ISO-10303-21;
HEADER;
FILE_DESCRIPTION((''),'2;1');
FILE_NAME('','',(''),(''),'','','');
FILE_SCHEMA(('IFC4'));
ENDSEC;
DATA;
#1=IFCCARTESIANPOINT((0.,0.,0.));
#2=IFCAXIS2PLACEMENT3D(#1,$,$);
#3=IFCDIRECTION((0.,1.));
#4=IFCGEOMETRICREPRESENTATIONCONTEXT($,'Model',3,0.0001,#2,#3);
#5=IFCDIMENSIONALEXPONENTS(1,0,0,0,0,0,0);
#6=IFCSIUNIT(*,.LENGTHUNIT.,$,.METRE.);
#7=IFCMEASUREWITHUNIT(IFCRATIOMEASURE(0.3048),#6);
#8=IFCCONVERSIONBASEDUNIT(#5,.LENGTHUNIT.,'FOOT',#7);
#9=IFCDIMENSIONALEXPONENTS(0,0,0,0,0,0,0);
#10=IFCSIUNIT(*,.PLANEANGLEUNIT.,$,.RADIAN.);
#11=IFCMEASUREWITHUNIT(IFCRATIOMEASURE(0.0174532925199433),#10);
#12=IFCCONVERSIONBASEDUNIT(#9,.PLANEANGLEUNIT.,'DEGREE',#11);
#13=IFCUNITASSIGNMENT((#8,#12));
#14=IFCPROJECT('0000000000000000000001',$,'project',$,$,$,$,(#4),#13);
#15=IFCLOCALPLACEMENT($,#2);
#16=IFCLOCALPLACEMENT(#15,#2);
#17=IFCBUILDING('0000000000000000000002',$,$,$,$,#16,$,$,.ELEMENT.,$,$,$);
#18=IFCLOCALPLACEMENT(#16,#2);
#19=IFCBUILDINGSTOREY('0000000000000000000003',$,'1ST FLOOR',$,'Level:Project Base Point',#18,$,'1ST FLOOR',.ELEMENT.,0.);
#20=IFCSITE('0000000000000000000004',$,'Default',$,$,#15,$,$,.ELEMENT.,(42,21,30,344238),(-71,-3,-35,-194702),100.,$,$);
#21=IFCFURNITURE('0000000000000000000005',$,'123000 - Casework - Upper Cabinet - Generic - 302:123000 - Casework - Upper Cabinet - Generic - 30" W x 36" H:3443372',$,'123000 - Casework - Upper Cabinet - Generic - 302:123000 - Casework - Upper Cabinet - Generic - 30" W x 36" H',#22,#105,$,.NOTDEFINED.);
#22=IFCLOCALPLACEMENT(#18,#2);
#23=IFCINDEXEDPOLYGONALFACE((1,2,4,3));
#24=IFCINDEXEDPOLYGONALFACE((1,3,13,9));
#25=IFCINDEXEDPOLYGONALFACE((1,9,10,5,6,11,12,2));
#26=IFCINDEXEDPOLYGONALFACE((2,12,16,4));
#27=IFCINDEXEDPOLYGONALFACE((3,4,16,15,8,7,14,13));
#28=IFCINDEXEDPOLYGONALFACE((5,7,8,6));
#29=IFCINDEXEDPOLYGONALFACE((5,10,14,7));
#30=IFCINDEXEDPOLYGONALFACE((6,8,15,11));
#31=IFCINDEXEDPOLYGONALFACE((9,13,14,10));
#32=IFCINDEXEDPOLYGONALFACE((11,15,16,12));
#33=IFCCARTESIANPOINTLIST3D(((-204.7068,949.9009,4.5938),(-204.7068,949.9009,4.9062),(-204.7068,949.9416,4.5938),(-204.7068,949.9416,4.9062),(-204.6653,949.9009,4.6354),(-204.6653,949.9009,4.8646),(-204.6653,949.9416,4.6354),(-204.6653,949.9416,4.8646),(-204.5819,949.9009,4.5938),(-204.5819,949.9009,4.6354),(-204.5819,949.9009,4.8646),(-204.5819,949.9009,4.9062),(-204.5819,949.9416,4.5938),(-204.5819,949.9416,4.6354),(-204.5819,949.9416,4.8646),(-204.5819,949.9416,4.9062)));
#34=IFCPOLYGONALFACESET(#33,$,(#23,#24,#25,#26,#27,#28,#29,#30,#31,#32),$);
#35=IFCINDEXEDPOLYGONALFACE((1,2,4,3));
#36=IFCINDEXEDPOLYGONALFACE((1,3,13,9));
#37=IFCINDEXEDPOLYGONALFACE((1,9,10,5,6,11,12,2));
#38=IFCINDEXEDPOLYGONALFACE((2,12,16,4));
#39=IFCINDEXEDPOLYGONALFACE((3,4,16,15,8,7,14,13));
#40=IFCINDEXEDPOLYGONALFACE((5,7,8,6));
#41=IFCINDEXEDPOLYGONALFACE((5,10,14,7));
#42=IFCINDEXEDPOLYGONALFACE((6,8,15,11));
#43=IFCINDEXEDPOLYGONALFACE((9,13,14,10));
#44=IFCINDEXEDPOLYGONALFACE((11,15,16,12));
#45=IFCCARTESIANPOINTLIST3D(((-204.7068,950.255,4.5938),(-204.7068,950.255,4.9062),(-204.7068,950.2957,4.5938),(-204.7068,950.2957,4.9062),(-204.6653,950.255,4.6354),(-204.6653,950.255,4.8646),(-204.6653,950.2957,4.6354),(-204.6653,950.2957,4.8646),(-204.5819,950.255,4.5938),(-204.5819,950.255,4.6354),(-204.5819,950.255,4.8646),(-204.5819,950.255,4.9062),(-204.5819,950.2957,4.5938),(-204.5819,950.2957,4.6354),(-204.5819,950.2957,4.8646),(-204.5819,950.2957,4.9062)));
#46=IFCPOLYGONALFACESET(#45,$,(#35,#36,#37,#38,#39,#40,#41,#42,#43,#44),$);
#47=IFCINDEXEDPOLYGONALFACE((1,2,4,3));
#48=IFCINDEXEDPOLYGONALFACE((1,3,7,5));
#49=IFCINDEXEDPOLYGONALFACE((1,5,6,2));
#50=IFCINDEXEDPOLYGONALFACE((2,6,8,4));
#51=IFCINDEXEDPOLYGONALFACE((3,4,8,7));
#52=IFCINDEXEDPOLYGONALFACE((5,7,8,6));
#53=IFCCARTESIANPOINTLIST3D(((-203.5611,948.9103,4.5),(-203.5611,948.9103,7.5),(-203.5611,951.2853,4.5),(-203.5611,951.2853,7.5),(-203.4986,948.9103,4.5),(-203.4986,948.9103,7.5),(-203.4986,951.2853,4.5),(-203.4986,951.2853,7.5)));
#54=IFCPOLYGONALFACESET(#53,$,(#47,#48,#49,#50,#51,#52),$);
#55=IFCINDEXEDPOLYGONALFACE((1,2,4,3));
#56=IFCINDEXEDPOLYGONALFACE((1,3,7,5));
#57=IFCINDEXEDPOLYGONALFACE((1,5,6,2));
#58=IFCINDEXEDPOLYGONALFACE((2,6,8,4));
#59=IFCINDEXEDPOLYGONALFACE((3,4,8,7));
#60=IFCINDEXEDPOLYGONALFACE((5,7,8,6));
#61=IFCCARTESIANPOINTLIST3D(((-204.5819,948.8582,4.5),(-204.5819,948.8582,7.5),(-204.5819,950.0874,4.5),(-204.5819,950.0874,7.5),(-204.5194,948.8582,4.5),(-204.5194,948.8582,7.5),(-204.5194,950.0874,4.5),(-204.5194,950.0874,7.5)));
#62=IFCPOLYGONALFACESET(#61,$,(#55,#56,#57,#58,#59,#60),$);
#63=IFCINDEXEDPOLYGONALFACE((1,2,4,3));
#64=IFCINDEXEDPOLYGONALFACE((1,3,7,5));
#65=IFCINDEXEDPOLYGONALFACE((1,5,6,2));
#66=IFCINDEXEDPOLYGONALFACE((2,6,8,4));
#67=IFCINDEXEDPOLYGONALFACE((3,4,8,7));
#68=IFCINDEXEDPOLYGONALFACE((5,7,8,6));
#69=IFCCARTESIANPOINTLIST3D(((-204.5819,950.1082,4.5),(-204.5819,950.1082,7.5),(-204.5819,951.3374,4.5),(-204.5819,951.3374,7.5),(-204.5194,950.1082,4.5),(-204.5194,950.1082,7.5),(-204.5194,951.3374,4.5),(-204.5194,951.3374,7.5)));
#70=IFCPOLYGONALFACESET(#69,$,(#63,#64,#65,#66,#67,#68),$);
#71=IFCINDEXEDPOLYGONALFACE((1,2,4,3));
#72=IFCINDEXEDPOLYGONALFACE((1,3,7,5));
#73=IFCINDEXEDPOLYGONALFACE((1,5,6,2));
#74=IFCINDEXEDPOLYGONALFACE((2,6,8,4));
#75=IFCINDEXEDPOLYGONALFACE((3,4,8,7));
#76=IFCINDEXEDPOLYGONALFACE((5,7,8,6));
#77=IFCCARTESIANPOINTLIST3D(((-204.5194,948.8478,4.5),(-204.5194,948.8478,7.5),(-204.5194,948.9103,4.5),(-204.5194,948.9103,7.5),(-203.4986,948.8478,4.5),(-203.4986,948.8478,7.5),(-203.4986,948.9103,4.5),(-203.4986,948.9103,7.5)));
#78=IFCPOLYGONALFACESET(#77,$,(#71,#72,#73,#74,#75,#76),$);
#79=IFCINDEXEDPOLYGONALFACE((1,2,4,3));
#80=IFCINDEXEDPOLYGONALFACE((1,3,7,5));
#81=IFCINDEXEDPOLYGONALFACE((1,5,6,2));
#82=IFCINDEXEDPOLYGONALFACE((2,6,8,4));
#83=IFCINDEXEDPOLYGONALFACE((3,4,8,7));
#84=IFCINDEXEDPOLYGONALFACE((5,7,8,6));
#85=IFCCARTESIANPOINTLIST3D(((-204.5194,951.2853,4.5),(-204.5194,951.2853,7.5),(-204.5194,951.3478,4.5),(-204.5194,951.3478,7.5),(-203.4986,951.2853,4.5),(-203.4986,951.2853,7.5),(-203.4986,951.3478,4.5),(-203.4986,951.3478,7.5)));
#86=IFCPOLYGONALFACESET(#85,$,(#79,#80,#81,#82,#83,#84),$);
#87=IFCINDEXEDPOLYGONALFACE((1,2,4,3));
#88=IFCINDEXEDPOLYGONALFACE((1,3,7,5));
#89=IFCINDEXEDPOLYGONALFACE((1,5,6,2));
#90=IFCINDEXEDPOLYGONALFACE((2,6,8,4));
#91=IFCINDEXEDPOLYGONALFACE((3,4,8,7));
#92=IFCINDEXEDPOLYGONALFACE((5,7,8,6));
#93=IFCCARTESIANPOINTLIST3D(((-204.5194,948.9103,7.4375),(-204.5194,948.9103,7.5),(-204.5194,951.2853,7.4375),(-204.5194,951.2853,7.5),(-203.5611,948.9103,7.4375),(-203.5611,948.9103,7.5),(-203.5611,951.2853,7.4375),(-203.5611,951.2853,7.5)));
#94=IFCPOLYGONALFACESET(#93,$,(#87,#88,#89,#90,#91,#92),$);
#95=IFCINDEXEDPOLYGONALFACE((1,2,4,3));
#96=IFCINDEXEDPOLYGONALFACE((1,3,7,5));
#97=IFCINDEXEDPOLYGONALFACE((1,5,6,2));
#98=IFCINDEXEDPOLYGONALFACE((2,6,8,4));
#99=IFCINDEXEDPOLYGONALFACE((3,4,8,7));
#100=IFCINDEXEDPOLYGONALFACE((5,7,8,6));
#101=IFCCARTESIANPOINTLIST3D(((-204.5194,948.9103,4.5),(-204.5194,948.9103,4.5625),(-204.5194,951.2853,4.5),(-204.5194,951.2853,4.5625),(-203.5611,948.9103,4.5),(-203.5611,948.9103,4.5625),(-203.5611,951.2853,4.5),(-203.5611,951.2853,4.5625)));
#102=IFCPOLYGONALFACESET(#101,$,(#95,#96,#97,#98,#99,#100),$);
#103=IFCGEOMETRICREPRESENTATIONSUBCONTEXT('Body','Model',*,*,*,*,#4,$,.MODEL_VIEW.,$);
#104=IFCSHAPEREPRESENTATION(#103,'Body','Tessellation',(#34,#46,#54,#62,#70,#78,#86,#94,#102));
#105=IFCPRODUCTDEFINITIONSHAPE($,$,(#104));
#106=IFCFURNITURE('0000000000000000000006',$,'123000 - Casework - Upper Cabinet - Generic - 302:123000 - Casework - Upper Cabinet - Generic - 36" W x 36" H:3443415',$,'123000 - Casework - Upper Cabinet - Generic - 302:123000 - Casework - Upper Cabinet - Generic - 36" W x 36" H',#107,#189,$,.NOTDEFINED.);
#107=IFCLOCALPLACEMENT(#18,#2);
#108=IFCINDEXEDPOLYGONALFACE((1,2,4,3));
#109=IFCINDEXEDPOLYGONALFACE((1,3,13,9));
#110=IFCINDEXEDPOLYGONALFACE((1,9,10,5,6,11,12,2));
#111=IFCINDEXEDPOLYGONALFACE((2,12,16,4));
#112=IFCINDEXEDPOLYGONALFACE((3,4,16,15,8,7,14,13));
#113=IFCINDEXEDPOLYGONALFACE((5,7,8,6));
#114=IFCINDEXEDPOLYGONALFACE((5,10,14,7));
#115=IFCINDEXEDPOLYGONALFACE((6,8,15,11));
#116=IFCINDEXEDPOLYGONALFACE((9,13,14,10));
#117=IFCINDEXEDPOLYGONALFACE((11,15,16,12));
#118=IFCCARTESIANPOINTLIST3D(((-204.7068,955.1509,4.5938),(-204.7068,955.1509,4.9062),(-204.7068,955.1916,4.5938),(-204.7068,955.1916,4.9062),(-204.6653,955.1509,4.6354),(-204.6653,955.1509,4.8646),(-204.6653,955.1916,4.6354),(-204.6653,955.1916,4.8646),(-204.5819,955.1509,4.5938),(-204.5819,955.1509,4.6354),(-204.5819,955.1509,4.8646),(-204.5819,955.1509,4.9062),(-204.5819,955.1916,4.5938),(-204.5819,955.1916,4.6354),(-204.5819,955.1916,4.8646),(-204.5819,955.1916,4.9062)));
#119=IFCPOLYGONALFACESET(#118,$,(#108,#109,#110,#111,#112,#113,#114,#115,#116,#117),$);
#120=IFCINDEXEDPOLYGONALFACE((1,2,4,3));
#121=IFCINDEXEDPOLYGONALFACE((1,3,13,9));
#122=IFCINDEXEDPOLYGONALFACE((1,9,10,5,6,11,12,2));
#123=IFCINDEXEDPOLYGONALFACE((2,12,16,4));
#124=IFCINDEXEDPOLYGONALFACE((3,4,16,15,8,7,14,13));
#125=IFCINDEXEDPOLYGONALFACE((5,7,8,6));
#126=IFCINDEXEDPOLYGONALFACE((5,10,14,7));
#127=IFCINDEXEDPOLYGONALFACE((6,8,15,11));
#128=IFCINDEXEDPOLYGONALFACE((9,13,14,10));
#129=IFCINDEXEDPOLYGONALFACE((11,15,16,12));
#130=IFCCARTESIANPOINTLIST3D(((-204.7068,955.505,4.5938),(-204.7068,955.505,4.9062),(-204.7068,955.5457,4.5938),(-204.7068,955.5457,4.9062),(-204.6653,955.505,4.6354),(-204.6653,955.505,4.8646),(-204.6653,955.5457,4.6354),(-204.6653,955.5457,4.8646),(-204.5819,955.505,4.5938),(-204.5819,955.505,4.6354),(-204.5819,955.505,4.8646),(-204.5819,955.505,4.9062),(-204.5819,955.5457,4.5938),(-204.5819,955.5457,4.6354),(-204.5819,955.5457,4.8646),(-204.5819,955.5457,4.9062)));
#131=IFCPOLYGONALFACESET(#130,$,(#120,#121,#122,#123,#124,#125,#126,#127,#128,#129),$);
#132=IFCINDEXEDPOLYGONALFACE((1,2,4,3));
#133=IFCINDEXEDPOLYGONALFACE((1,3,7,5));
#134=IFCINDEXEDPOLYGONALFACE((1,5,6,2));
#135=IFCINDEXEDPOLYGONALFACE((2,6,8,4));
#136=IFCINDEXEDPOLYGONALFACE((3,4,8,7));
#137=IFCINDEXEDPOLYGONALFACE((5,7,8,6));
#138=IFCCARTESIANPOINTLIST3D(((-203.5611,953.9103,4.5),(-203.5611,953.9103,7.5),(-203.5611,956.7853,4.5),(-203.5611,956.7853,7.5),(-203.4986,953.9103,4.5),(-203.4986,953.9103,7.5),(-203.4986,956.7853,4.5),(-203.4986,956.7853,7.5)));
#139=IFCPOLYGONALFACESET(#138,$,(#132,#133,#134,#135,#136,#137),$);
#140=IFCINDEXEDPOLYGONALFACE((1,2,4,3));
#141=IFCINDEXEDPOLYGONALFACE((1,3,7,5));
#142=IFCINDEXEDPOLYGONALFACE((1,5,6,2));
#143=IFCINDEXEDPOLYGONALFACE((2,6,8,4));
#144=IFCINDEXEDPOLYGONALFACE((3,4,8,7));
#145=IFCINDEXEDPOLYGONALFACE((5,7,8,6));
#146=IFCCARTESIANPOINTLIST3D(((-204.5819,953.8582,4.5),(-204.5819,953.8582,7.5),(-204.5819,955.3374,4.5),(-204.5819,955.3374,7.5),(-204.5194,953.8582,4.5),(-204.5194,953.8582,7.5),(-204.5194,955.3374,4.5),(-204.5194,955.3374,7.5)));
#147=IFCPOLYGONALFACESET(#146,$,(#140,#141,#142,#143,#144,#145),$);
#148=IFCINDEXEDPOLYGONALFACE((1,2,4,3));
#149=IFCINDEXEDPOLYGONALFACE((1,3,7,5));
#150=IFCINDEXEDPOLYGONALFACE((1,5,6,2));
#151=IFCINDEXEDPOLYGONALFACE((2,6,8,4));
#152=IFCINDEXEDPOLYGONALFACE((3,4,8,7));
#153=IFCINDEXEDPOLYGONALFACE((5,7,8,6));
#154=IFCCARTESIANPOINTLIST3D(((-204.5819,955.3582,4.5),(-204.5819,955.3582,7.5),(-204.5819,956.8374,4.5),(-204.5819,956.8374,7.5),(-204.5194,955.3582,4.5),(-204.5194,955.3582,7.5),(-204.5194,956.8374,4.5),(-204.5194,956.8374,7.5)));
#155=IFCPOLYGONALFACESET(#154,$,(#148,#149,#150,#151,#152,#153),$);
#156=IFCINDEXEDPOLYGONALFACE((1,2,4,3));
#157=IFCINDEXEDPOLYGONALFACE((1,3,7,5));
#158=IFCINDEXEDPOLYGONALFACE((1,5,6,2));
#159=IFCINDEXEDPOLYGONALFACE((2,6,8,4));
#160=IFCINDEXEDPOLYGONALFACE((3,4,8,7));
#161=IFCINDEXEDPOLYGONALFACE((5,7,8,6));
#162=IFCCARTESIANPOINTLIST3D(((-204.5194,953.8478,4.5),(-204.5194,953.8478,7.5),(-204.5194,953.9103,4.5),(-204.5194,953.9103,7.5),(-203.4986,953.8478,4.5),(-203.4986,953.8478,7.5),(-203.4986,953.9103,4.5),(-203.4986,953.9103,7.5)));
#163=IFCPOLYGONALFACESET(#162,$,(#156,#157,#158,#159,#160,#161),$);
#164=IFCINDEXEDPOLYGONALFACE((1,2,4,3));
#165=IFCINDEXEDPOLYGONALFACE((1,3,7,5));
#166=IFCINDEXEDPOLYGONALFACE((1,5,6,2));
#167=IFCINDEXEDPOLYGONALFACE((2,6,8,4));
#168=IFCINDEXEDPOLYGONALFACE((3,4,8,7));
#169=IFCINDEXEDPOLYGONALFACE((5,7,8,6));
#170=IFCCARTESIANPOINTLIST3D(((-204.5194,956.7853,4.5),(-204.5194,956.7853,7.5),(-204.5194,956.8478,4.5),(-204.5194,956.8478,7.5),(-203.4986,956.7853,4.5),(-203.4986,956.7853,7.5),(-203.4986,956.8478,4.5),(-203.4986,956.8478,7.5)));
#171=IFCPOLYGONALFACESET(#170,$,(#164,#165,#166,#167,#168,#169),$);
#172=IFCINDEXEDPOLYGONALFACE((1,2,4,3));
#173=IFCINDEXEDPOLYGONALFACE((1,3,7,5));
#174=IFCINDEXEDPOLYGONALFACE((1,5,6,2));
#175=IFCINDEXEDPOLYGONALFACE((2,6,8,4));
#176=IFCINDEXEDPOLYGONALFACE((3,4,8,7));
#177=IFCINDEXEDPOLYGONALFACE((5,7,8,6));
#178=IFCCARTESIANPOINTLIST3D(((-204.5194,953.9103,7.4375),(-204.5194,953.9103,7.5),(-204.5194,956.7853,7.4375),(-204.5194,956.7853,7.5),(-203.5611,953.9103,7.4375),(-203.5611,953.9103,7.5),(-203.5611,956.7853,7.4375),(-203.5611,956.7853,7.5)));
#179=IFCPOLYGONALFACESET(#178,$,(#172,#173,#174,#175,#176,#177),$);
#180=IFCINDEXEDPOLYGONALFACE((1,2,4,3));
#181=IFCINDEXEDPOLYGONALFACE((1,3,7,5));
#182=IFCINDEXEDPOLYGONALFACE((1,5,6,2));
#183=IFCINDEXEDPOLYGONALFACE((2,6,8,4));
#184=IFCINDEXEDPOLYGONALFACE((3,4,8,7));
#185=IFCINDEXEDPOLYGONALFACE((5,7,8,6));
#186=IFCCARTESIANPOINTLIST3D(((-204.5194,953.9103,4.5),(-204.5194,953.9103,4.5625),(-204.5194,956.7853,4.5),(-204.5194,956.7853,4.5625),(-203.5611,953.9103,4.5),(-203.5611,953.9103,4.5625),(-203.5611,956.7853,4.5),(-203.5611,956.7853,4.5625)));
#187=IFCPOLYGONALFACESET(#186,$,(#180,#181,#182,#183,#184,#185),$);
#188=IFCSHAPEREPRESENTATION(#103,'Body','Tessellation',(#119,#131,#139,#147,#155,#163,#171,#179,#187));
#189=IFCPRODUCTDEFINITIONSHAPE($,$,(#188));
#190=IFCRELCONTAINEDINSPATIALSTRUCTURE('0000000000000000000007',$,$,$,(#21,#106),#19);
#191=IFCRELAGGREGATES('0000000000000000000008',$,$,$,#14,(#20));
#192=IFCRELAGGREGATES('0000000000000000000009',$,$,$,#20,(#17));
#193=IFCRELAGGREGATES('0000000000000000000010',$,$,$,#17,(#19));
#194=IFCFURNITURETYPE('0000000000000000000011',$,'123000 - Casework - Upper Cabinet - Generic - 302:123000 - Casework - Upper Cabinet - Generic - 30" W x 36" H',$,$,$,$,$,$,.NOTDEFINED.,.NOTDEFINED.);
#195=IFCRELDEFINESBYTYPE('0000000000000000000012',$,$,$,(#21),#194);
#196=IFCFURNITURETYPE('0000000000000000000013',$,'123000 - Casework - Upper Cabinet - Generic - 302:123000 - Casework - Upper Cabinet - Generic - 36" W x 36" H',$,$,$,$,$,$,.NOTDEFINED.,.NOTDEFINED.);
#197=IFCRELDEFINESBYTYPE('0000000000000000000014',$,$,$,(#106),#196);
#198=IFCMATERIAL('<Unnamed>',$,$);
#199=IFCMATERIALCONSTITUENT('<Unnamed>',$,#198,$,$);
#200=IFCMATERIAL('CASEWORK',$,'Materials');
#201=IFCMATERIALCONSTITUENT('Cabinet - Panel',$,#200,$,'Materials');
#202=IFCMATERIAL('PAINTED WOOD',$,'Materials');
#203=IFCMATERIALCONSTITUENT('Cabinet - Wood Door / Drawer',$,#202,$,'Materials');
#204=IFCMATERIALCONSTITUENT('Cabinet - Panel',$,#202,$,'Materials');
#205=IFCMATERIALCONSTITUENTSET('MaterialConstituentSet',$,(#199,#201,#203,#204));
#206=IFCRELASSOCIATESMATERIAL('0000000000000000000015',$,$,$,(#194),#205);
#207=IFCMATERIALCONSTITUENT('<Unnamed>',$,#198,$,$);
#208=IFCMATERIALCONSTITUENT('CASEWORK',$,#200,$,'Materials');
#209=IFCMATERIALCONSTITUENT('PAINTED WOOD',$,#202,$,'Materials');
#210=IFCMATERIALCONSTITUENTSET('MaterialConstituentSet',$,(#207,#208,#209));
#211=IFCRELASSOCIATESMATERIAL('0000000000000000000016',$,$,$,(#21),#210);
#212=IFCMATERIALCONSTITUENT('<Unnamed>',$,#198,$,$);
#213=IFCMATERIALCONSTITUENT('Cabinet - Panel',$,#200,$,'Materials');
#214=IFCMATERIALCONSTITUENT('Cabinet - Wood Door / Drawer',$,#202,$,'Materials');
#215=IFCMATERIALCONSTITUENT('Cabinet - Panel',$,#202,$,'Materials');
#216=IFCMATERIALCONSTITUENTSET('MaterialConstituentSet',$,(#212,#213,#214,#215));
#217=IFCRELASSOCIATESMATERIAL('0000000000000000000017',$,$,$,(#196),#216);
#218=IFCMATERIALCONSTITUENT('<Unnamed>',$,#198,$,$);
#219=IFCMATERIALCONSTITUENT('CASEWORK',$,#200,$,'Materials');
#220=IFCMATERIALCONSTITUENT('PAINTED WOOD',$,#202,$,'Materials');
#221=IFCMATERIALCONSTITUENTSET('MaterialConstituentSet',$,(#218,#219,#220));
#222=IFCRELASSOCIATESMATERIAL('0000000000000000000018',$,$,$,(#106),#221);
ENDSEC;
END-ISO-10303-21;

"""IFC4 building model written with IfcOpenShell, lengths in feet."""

from ifc_helpers import new_model, entity, si_unit, converted_unit, direction, frame, frame_2d, origin, origin_2d_with_axis, place, context, subcontext, project, spatial, polyline, rectangle, outline, extrude, source, transform, mapped, material, constituent, constituent_set, type_object, type_shapes, element, save


model = new_model("IFC4")

# Units and contexts
model_context = context("Model", 3, precision=0.0001, world=origin(), true_north=direction((0.0, 1.0)))
body_context = subcontext(model_context, "Body", "Model", "MODEL_VIEW")
ifc_project = project(units=[converted_unit("LENGTHUNIT", "FOOT", entity("IfcRatioMeasure", 0.3048), si_unit("LENGTHUNIT", "METRE"), dimensions=[1, 0, 0, 0, 0, 0, 0]), converted_unit("PLANEANGLEUNIT", "DEGREE", entity("IfcRatioMeasure", 0.0174532925199433), si_unit("PLANEANGLEUNIT", "RADIAN"), dimensions=[0, 0, 0, 0, 0, 0, 0])], contexts=[model_context])

# Site, building, storey
site_placement = place(None, origin())
site = spatial("IfcSite", under=ifc_project, at=site_placement, Name="Default", CompositionType="ELEMENT", RefLatitude=(42, 21, 30, 344238), RefLongitude=(-71, -3, -35, -194702), RefElevation=100.0)
building_placement = place(site_placement, origin())
building = spatial("IfcBuilding", under=site, at=building_placement, CompositionType="ELEMENT")
storey_placement = place(building_placement, origin())
storey = spatial("IfcBuildingStorey", under=building, at=storey_placement, Name="1ST FLOOR", ObjectType="Level:Project Base Point", LongName="1ST FLOOR", CompositionType="ELEMENT", Elevation=0.0)

# Furniture
ifc_material_1 = material(Name="PAINTED WOOD", Category="Materials")
ifc_material_2 = material(Name="CASEWORK", Category="Materials")
ifc_material_3 = material(Name="<Unnamed>")
ifc_constituent_1 = constituent(ifc_material_3, Name="<Unnamed>")
ifc_constituent_2 = constituent(ifc_material_2, Name="CASEWORK", Category="Materials")
ifc_constituent_3 = constituent(ifc_material_1, Name="PAINTED WOOD", Category="Materials")
ifc_constituent_set_1 = constituent_set(constituents=[ifc_constituent_1, ifc_constituent_2, ifc_constituent_3], Name="MaterialConstituentSet")
ifc_constituent_4 = constituent(ifc_material_3, Name="<Unnamed>")
ifc_constituent_5 = constituent(ifc_material_2, Name="Cabinet - Panel", Category="Materials")
ifc_constituent_6 = constituent(ifc_material_1, Name="Cabinet - Wood Door / Drawer", Category="Materials")
ifc_constituent_7 = constituent(ifc_material_1, Name="Cabinet - Panel", Category="Materials")
ifc_constituent_set_2 = constituent_set(constituents=[ifc_constituent_4, ifc_constituent_5, ifc_constituent_6, ifc_constituent_7], Name="MaterialConstituentSet")
furniture_type_1 = type_object("IfcFurnitureType", Name="123000 - Casework - Upper Cabinet - Generic - 302:123000 - Casework - Upper Cabinet - Generic - 30\" W x 36\" H", AssemblyPlace="NOTDEFINED", PredefinedType="NOTDEFINED", material=ifc_constituent_set_2)
shared_shape_1 = source(origin(), body_context, "Body", "SweptSolid", [
    extrude(outline(polyline([(-0.0521, -0.1146), (-0.0521, -0.1562), (0.0729, -0.1562), (0.0729, 0.1562), (-0.0521, 0.1562), (-0.0521, 0.1146), (0.0313, 0.1146), (0.0313, -0.1146), (-0.0521, -0.1146)])), frame((1.053, 1.1354, 0.25), z_axis=(-1.0, 0.0, 0.0), x_axis=(0.0, 1.0, 0.0)), (0.0, 0.0, -1.0), 0.0407),
    extrude(outline(polyline([(-0.0521, -0.1146), (-0.0521, -0.1562), (0.0729, -0.1562), (0.0729, 0.1562), (-0.0521, 0.1562), (-0.0521, 0.1146), (0.0313, 0.1146), (0.0313, -0.1146), (-0.0521, -0.1146)])), frame((1.4072, 1.1354, 0.25), z_axis=(-1.0, 0.0, 0.0), x_axis=(0.0, 1.0, 0.0)), (0.0, 0.0, -1.0), 0.0407),
    extrude(rectangle(XDim=2.375, YDim=0.0625, at=frame_2d((0.0, 0.0), x_axis=(1.0, 0.0))), frame((1.25, 0.0313, 0.0), z_axis=(0.0, 0.0, 1.0), x_axis=(-1.0, 0.0, 0.0)), (0.0, 0.0, 1.0), 3.0),
    extrude(rectangle(XDim=1.2292, YDim=0.0625, at=origin_2d_with_axis()), frame((0.625, 1.0521, 0.0)), (0.0, 0.0, 1.0), 3.0),
    extrude(rectangle(XDim=1.2292, YDim=0.0625, at=origin_2d_with_axis()), frame((1.875, 1.0521, 0.0)), (0.0, 0.0, 1.0), 3.0),
    extrude(rectangle(XDim=1.0208, YDim=0.0625, at=origin_2d_with_axis()), frame((0.0312, 0.5104, 0.0), z_axis=(0.0, 0.0, 1.0), x_axis=(0.0, 1.0, 0.0)), (0.0, 0.0, 1.0), 3.0),
    extrude(rectangle(XDim=1.0208, YDim=0.0625, at=frame_2d((0.0, 0.0), x_axis=(1.0, 0.0))), frame((2.4688, 0.5104, 0.0), z_axis=(0.0, 0.0, 1.0), x_axis=(0.0, 1.0, 0.0)), (0.0, 0.0, 1.0), 3.0),
    extrude(rectangle(XDim=0.9583, YDim=2.375, at=frame_2d((0.0, 0.0), x_axis=(1.0, 0.0))), frame((1.25, 0.5417, 2.9375), z_axis=(0.0, 0.0, 1.0), x_axis=(0.0, 1.0, 0.0)), (0.0, 0.0, 1.0), 0.0625),
    extrude(rectangle(XDim=0.9583, YDim=2.375, at=origin_2d_with_axis()), frame((1.25, 0.5417, 0.0), z_axis=(0.0, 0.0, 1.0), x_axis=(0.0, 1.0, 0.0)), (0.0, 0.0, 1.0), 0.0625),
])
type_shapes(furniture_type_1, [shared_shape_1])
furniture_1_placement = place(storey_placement, frame((-203.4986, 948.8478, 4.5), z_axis=(0.0, 0.0, 1.0), x_axis=(0.0, 1.0, 0.0)))
element("IfcFurniture", 1, at=furniture_1_placement, inside=storey, type_object=furniture_type_1, material=ifc_constituent_set_1, Name="123000 - Casework - Upper Cabinet - Generic - 302:123000 - Casework - Upper Cabinet - Generic - 30\" W x 36\" H:3443372", ObjectType="123000 - Casework - Upper Cabinet - Generic - 302:123000 - Casework - Upper Cabinet - Generic - 30\" W x 36\" H", PredefinedType="NOTDEFINED", context=body_context, shape_type="MappedRepresentation", body=[
    mapped(shared_shape_1, transform((0.0, 0.0, 0.0), scale=1.0)),
])
ifc_constituent_8 = constituent(ifc_material_3, Name="<Unnamed>")
ifc_constituent_9 = constituent(ifc_material_2, Name="CASEWORK", Category="Materials")
ifc_constituent_10 = constituent(ifc_material_1, Name="PAINTED WOOD", Category="Materials")
ifc_constituent_set_3 = constituent_set(constituents=[ifc_constituent_8, ifc_constituent_9, ifc_constituent_10], Name="MaterialConstituentSet")
ifc_constituent_11 = constituent(ifc_material_3, Name="<Unnamed>")
ifc_constituent_12 = constituent(ifc_material_2, Name="Cabinet - Panel", Category="Materials")
ifc_constituent_13 = constituent(ifc_material_1, Name="Cabinet - Wood Door / Drawer", Category="Materials")
ifc_constituent_14 = constituent(ifc_material_1, Name="Cabinet - Panel", Category="Materials")
ifc_constituent_set_4 = constituent_set(constituents=[ifc_constituent_11, ifc_constituent_12, ifc_constituent_13, ifc_constituent_14], Name="MaterialConstituentSet")
furniture_type_2 = type_object("IfcFurnitureType", Name="123000 - Casework - Upper Cabinet - Generic - 302:123000 - Casework - Upper Cabinet - Generic - 36\" W x 36\" H", AssemblyPlace="NOTDEFINED", PredefinedType="NOTDEFINED", material=ifc_constituent_set_4)
shared_shape_2 = source(origin(), body_context, "Body", "SweptSolid", [
    extrude(outline(polyline([(-0.0521, -0.1146), (-0.0521, -0.1562), (0.0729, -0.1562), (0.0729, 0.1562), (-0.0521, 0.1562), (-0.0521, 0.1146), (0.0313, 0.1146), (0.0313, -0.1146), (-0.0521, -0.1146)])), frame((1.303, 1.1354, 0.25), z_axis=(-1.0, 0.0, 0.0), x_axis=(0.0, 1.0, 0.0)), (0.0, 0.0, -1.0), 0.0407),
    extrude(outline(polyline([(-0.0521, -0.1146), (-0.0521, -0.1562), (0.0729, -0.1562), (0.0729, 0.1562), (-0.0521, 0.1562), (-0.0521, 0.1146), (0.0313, 0.1146), (0.0313, -0.1146), (-0.0521, -0.1146)])), frame((1.6572, 1.1354, 0.25), z_axis=(-1.0, 0.0, 0.0), x_axis=(0.0, 1.0, 0.0)), (0.0, 0.0, -1.0), 0.0407),
    extrude(rectangle(XDim=2.875, YDim=0.0625, at=frame_2d((0.0, 0.0), x_axis=(1.0, 0.0))), frame((1.5, 0.0313, 0.0), z_axis=(0.0, 0.0, 1.0), x_axis=(-1.0, 0.0, 0.0)), (0.0, 0.0, 1.0), 3.0),
    extrude(rectangle(XDim=1.4792, YDim=0.0625, at=origin_2d_with_axis()), frame((0.75, 1.0521, 0.0)), (0.0, 0.0, 1.0), 3.0),
    extrude(rectangle(XDim=1.4792, YDim=0.0625, at=origin_2d_with_axis()), frame((2.25, 1.0521, 0.0)), (0.0, 0.0, 1.0), 3.0),
    extrude(rectangle(XDim=1.0208, YDim=0.0625, at=origin_2d_with_axis()), frame((0.0312, 0.5104, 0.0), z_axis=(0.0, 0.0, 1.0), x_axis=(0.0, 1.0, 0.0)), (0.0, 0.0, 1.0), 3.0),
    extrude(rectangle(XDim=1.0208, YDim=0.0625, at=frame_2d((0.0, 0.0), x_axis=(1.0, 0.0))), frame((2.9688, 0.5104, 0.0), z_axis=(0.0, 0.0, 1.0), x_axis=(0.0, 1.0, 0.0)), (0.0, 0.0, 1.0), 3.0),
    extrude(rectangle(XDim=0.9583, YDim=2.875, at=frame_2d((0.0, 0.0), x_axis=(1.0, 0.0))), frame((1.5, 0.5417, 2.9375), z_axis=(0.0, 0.0, 1.0), x_axis=(0.0, 1.0, 0.0)), (0.0, 0.0, 1.0), 0.0625),
    extrude(rectangle(XDim=0.9583, YDim=2.875, at=frame_2d((0.0, 0.0), x_axis=(1.0, 0.0))), frame((1.5, 0.5417, 0.0), z_axis=(0.0, 0.0, 1.0), x_axis=(0.0, 1.0, 0.0)), (0.0, 0.0, 1.0), 0.0625),
])
type_shapes(furniture_type_2, [shared_shape_2])
furniture_2_placement = place(storey_placement, frame((-203.4986, 953.8478, 4.5), z_axis=(0.0, 0.0, 1.0), x_axis=(0.0, 1.0, 0.0)))
element("IfcFurniture", 2, at=furniture_2_placement, inside=storey, type_object=furniture_type_2, material=ifc_constituent_set_3, Name="123000 - Casework - Upper Cabinet - Generic - 302:123000 - Casework - Upper Cabinet - Generic - 36\" W x 36\" H:3443415", ObjectType="123000 - Casework - Upper Cabinet - Generic - 302:123000 - Casework - Upper Cabinet - Generic - 36\" W x 36\" H", PredefinedType="NOTDEFINED", context=body_context, shape_type="MappedRepresentation", body=[
    mapped(shared_shape_2, transform((0.0, 0.0, 0.0), scale=1.0)),
])

save(model, "model.ifc")
